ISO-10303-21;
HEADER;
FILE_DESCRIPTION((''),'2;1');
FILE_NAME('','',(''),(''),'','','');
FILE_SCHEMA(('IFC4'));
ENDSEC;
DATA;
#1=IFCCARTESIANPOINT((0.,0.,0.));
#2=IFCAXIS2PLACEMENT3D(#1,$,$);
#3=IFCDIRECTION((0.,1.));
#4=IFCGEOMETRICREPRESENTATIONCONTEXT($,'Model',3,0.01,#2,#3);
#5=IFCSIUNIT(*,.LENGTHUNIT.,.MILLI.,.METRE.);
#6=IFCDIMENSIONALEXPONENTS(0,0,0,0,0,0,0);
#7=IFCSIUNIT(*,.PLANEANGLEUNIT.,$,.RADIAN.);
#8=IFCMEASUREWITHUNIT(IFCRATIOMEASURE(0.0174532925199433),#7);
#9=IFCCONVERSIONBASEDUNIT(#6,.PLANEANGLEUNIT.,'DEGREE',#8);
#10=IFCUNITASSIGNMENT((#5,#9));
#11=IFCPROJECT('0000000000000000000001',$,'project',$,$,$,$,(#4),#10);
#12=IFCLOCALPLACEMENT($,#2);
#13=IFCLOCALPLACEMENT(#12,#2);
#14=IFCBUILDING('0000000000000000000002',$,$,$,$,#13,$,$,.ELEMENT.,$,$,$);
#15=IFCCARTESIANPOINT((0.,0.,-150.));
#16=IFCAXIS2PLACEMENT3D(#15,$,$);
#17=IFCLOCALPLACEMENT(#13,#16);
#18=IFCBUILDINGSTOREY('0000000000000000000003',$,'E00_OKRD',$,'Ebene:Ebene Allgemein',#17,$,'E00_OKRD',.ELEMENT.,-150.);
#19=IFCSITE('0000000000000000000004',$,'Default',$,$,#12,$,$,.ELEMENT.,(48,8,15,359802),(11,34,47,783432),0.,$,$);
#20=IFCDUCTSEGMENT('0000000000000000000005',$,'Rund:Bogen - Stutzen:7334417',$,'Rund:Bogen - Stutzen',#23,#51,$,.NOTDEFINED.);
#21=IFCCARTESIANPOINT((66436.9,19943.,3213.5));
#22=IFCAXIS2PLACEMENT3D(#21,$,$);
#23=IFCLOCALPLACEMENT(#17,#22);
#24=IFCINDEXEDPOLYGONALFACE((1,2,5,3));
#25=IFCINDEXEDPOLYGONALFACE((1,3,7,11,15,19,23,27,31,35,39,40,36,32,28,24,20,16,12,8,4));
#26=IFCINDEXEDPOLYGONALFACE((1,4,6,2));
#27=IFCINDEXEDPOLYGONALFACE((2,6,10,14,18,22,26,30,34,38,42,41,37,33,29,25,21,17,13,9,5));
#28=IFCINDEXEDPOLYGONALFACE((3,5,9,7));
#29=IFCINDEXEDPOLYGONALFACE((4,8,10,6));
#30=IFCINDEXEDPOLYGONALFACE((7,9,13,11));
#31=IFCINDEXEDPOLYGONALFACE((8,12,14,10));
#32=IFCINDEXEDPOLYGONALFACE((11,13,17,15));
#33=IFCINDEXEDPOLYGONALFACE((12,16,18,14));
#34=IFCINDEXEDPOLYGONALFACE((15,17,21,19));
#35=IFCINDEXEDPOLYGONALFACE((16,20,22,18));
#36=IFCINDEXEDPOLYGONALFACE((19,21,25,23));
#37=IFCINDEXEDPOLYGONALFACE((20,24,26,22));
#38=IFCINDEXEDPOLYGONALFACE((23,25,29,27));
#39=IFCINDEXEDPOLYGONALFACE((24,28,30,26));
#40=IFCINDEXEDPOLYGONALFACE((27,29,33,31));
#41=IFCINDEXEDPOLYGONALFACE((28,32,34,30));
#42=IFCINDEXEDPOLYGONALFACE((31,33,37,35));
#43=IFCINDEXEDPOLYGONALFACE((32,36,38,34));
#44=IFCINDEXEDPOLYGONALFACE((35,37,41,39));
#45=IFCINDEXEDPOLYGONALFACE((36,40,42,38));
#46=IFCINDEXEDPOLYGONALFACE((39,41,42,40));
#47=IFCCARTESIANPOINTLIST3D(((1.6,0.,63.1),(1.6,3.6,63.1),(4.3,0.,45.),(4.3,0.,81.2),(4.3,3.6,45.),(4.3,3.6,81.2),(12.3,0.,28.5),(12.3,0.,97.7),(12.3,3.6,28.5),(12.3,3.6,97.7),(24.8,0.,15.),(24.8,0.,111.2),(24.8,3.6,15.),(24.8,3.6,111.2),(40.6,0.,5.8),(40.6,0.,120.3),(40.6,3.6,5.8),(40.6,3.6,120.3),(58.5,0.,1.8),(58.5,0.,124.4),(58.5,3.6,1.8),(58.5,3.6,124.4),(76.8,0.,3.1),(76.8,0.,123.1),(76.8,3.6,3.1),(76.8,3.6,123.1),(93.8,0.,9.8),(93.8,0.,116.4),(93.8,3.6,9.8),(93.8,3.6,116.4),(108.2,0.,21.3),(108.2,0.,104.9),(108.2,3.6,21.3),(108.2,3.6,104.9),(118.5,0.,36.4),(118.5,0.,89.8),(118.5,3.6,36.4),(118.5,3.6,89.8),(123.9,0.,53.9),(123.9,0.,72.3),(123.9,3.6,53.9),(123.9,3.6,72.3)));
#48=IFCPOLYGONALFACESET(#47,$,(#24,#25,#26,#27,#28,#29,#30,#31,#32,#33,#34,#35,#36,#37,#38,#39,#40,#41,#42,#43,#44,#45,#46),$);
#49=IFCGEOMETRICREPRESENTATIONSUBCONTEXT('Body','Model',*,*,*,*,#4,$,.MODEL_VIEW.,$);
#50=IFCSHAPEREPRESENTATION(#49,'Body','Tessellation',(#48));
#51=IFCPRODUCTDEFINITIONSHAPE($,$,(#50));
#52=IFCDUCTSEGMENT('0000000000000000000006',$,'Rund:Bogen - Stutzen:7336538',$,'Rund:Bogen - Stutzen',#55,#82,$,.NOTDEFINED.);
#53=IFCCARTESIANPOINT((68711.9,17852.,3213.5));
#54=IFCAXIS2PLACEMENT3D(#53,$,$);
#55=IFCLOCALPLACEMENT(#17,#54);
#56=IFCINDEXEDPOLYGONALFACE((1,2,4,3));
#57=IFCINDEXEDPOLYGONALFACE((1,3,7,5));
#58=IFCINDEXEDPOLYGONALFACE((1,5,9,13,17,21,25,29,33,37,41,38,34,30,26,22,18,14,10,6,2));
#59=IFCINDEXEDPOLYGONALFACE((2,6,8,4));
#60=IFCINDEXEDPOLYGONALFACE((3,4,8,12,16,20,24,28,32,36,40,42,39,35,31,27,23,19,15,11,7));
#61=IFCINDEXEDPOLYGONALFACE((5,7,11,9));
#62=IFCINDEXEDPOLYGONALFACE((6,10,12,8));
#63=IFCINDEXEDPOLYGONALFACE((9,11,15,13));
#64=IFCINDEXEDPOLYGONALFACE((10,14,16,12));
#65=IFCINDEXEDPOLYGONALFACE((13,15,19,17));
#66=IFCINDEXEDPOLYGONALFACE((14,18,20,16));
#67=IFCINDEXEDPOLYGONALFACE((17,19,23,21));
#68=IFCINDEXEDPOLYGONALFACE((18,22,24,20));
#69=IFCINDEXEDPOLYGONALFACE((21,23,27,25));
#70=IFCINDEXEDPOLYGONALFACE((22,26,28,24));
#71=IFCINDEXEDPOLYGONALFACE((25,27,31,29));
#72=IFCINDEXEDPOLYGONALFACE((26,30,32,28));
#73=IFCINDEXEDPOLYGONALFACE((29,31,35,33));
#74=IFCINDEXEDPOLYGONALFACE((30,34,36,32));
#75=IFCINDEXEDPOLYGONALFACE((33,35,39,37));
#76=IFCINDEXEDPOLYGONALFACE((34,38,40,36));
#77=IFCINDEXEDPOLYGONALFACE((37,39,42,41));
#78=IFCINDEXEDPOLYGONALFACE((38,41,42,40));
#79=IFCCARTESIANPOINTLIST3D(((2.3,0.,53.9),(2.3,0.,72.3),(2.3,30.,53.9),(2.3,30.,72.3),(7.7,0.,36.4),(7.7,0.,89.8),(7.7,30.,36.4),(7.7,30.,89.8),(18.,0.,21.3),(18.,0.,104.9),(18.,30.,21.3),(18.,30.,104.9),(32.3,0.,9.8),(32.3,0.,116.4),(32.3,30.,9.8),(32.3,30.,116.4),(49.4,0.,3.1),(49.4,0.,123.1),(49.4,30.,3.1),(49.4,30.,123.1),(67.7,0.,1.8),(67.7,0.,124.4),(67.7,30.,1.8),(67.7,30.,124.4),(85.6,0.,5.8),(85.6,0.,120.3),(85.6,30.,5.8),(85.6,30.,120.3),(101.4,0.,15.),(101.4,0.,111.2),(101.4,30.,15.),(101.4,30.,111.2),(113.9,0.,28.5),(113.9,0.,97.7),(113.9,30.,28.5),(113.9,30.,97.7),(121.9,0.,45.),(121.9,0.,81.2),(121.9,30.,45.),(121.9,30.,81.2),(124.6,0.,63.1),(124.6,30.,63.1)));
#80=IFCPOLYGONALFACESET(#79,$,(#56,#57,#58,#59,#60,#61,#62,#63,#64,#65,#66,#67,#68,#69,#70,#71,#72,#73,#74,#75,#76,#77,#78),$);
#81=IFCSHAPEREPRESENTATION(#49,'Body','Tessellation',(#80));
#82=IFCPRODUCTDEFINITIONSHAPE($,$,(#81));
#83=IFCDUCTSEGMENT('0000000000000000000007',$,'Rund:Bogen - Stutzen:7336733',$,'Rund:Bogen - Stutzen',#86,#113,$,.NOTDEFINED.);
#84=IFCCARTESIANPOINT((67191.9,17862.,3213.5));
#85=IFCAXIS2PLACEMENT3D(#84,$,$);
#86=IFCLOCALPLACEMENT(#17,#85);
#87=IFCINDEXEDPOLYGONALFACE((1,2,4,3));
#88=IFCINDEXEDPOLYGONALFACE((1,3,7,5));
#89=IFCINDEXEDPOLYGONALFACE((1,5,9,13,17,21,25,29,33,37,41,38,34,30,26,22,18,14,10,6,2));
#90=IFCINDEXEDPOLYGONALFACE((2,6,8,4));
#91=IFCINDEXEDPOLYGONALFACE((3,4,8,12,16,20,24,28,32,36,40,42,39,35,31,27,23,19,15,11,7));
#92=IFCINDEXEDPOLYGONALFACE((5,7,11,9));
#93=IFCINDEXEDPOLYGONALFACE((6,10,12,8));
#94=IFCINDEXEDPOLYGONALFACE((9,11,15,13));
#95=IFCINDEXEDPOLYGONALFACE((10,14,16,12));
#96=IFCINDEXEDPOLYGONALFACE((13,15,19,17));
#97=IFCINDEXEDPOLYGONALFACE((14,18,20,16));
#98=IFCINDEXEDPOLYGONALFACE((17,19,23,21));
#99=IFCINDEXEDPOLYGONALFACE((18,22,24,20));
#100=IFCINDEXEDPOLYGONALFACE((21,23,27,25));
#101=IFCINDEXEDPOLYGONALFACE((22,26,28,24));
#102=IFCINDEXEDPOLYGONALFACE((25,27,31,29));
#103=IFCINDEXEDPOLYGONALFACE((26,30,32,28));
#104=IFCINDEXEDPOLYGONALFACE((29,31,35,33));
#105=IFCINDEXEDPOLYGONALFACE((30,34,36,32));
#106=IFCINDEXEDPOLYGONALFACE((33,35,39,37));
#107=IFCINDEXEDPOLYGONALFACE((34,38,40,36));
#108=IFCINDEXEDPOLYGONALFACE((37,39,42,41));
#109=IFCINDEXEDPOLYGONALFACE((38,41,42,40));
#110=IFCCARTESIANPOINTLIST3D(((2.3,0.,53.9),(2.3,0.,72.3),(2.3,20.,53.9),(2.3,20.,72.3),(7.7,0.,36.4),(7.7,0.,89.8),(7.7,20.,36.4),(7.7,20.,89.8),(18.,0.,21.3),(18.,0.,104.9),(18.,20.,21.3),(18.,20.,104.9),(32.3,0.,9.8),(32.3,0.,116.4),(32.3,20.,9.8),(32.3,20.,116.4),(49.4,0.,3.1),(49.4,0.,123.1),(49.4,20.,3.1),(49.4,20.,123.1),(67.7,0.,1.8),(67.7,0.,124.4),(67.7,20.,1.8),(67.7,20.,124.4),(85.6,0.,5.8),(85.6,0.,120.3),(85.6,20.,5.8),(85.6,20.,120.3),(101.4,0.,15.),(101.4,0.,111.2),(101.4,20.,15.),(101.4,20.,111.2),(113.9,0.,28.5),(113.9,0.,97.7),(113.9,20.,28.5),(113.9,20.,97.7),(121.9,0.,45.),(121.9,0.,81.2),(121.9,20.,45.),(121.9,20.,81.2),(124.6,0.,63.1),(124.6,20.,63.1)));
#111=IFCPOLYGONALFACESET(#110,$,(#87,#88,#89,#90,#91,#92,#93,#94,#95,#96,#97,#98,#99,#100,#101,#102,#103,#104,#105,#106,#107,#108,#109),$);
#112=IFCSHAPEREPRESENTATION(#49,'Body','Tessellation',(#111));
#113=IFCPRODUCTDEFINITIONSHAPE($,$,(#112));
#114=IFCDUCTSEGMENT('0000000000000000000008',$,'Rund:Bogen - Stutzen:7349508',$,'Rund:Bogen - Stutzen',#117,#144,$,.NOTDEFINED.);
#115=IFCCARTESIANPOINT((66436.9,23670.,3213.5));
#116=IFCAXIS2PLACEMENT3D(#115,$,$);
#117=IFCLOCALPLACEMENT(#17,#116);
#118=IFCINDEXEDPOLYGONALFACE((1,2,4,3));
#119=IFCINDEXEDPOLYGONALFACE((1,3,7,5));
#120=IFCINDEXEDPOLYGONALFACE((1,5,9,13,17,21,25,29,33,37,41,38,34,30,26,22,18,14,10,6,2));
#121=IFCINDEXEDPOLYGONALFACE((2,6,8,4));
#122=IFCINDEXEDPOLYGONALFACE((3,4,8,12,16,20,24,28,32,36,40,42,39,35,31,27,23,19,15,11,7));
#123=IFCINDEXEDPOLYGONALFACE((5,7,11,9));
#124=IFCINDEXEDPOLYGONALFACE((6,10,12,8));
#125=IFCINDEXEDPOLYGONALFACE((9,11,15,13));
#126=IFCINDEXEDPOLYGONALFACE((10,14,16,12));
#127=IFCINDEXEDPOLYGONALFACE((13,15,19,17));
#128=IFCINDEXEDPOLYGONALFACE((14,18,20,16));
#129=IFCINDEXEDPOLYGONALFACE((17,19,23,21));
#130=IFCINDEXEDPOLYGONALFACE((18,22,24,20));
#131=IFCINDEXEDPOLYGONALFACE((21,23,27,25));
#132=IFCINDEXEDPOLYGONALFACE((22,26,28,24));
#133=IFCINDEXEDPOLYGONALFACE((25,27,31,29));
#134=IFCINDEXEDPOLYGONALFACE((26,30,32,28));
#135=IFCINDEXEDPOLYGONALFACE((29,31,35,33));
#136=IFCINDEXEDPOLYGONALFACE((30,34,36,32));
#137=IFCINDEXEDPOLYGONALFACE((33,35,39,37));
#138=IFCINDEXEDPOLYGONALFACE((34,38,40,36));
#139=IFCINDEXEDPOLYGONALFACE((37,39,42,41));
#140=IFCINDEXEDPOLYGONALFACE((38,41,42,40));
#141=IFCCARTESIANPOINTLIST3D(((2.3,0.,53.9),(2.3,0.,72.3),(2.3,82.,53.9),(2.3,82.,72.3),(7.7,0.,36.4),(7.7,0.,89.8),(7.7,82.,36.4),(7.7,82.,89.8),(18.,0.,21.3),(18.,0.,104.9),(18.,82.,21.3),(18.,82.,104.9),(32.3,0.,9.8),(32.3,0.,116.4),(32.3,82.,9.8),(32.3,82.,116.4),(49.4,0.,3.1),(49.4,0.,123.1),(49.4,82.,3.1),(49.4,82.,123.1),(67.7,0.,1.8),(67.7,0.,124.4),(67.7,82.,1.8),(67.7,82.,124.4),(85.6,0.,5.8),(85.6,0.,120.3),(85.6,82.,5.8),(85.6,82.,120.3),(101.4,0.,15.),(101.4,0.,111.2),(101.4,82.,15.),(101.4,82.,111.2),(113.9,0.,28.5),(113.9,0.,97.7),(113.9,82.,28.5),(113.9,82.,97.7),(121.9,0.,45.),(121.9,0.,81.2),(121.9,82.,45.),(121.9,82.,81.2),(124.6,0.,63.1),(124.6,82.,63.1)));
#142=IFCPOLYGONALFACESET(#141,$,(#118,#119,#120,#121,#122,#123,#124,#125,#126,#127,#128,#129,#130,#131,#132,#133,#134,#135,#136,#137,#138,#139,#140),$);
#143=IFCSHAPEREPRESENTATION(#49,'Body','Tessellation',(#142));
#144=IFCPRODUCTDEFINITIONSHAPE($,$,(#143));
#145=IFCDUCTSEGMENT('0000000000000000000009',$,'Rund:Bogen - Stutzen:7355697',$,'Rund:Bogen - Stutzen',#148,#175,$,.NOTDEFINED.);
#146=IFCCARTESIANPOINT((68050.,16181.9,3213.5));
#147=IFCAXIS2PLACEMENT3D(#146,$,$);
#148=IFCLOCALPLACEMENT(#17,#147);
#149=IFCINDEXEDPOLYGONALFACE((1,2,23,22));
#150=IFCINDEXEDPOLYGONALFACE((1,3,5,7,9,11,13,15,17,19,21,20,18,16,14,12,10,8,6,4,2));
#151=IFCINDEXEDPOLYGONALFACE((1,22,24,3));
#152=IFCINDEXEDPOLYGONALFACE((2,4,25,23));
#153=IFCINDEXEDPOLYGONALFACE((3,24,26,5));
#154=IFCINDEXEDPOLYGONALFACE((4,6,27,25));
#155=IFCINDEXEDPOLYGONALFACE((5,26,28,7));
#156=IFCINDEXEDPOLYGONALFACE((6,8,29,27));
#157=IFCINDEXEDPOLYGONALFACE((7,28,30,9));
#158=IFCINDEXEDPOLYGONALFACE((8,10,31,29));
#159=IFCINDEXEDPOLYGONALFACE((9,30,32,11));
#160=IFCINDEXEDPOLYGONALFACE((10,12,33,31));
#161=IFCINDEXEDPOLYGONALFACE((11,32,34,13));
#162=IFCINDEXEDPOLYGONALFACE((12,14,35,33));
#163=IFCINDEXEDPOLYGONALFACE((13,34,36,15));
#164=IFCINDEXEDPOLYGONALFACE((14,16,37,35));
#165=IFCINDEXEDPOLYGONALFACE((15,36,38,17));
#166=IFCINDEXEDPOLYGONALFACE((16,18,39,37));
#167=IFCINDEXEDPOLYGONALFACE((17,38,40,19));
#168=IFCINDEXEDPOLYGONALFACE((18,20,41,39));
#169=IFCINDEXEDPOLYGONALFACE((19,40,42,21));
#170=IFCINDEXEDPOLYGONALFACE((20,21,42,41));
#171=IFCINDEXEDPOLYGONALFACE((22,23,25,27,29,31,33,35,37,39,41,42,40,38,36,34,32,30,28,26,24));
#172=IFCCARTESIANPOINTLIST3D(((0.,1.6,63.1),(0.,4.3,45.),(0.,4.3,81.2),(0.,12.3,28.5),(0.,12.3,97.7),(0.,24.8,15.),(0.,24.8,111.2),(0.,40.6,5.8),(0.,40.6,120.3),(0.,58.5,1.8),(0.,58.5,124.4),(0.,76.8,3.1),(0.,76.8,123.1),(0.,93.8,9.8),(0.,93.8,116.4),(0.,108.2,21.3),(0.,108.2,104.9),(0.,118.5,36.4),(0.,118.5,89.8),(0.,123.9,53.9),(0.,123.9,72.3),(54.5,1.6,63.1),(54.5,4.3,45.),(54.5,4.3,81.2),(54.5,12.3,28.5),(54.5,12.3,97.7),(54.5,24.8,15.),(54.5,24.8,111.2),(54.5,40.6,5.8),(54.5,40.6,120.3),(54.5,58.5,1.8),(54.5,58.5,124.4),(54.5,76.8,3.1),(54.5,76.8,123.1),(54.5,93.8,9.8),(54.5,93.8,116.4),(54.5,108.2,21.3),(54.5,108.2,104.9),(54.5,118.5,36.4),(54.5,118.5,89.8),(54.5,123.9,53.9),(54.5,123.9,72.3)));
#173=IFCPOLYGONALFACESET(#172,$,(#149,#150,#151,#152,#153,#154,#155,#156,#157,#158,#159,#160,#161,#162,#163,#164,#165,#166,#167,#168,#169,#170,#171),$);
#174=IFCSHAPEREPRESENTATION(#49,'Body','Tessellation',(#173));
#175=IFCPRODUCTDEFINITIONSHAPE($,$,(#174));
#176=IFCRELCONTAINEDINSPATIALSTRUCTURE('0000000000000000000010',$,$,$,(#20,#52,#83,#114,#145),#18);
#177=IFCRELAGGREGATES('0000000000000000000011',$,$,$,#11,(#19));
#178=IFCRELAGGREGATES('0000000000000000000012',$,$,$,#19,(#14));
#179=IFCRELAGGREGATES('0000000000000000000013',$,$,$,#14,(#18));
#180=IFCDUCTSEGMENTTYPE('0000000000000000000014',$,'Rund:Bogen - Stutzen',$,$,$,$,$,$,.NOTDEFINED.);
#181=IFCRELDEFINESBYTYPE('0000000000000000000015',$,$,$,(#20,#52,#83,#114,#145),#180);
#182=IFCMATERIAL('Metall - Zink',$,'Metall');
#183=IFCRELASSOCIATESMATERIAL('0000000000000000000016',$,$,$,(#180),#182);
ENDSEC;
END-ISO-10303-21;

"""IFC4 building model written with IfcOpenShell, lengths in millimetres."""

from ifc_helpers import new_model, entity, si_unit, converted_unit, direction, frame, frame_2d, origin, origin_2d_with_axis, place, context, subcontext, project, spatial, circle, extrude, material, type_object, element, save


model = new_model("IFC4")

# Units and contexts
model_context = context("Model", 3, precision=0.01, world=origin(), true_north=direction((0.0, 1.0)))
body_context = subcontext(model_context, "Body", "Model", "MODEL_VIEW")
ifc_project = project(units=[si_unit("LENGTHUNIT", "METRE", prefix="MILLI"), converted_unit("PLANEANGLEUNIT", "DEGREE", entity("IfcRatioMeasure", 0.0174532925199433), si_unit("PLANEANGLEUNIT", "RADIAN"), dimensions=[0, 0, 0, 0, 0, 0, 0])], contexts=[model_context])

# Site, building, storey
site_placement = place(None, origin())
site = spatial("IfcSite", under=ifc_project, at=site_placement, Name="Default", CompositionType="ELEMENT", RefLatitude=(48, 8, 15, 359802), RefLongitude=(11, 34, 47, 783432), RefElevation=0.0)
building_placement = place(site_placement, origin())
building = spatial("IfcBuilding", under=site, at=building_placement, CompositionType="ELEMENT")
storey_placement = place(building_placement, frame((0.0, 0.0, -150.0)))
storey = spatial("IfcBuildingStorey", under=building, at=storey_placement, Name="E00_OKRD", ObjectType="Ebene:Ebene Allgemein", LongName="E00_OKRD", CompositionType="ELEMENT", Elevation=-150.0)

# Shared definitions
ifc_material_1 = material(Name="Metall - Zink", Category="Metall")

# Duct segments
duct_segment_type_1 = type_object("IfcDuctSegmentType", Name="Rund:Bogen - Stutzen", PredefinedType="NOTDEFINED", material=ifc_material_1)
duct_segment_1_placement = place(storey_placement, frame((66436.9, 19943.0, 3213.5)))
element("IfcDuctSegment", 1, at=duct_segment_1_placement, inside=storey, type_object=duct_segment_type_1, Name="Rund:Bogen - Stutzen:7334417", ObjectType="Rund:Bogen - Stutzen", PredefinedType="NOTDEFINED", context=body_context, shape_type="SweptSolid", body=[
    extrude(circle(Radius=61.5, at=frame_2d((0.0, 0.0), x_axis=(1.0, 0.0))), frame((63.1, 0.0, 63.1), z_axis=(0.0, 1.0, 0.0), x_axis=(-1.0, 0.0, 0.0)), (0.0, 0.0, 1.0), 3.6),
])
duct_segment_2_placement = place(storey_placement, frame((68711.9, 17852.0, 3213.5)))
element("IfcDuctSegment", 2, at=duct_segment_2_placement, inside=storey, type_object=duct_segment_type_1, Name="Rund:Bogen - Stutzen:7336538", ObjectType="Rund:Bogen - Stutzen", PredefinedType="NOTDEFINED", context=body_context, shape_type="SweptSolid", body=[
    extrude(circle(Radius=61.5, at=frame_2d((0.0, 0.0), x_axis=(1.0, 0.0))), frame((63.1, 0.0, 63.1), z_axis=(0.0, 1.0, 0.0), x_axis=(1.0, 0.0, 0.0)), (0.0, 0.0, 1.0), 30.0),
])
duct_segment_3_placement = place(storey_placement, frame((67191.9, 17862.0, 3213.5)))
element("IfcDuctSegment", 3, at=duct_segment_3_placement, inside=storey, type_object=duct_segment_type_1, Name="Rund:Bogen - Stutzen:7336733", ObjectType="Rund:Bogen - Stutzen", PredefinedType="NOTDEFINED", context=body_context, shape_type="SweptSolid", body=[
    extrude(circle(Radius=61.5, at=frame_2d((0.0, 0.0), x_axis=(1.0, 0.0))), frame((63.1, 0.0, 63.1), z_axis=(0.0, 1.0, 0.0), x_axis=(1.0, 0.0, 0.0)), (0.0, 0.0, 1.0), 20.0),
])
duct_segment_4_placement = place(storey_placement, frame((66436.9, 23670.0, 3213.5)))
element("IfcDuctSegment", 4, at=duct_segment_4_placement, inside=storey, type_object=duct_segment_type_1, Name="Rund:Bogen - Stutzen:7349508", ObjectType="Rund:Bogen - Stutzen", PredefinedType="NOTDEFINED", context=body_context, shape_type="SweptSolid", body=[
    extrude(circle(Radius=61.5, at=frame_2d((0.0, 0.0), x_axis=(1.0, 0.0))), frame((63.1, 0.0, 63.1), z_axis=(0.0, 1.0, 0.0), x_axis=(1.0, 0.0, 0.0)), (0.0, 0.0, 1.0), 82.0),
])
duct_segment_5_placement = place(storey_placement, frame((68050.0, 16181.9, 3213.5)))
element("IfcDuctSegment", 5, at=duct_segment_5_placement, inside=storey, type_object=duct_segment_type_1, Name="Rund:Bogen - Stutzen:7355697", ObjectType="Rund:Bogen - Stutzen", PredefinedType="NOTDEFINED", context=body_context, shape_type="SweptSolid", body=[
    extrude(circle(Radius=61.5, at=origin_2d_with_axis()), frame((0.0, 63.1, 63.1), z_axis=(1.0, 0.0, 0.0), x_axis=(0.0, -1.0, 0.0)), (0.0, 0.0, 1.0), 54.5),
])

save(model, "model.ifc")
